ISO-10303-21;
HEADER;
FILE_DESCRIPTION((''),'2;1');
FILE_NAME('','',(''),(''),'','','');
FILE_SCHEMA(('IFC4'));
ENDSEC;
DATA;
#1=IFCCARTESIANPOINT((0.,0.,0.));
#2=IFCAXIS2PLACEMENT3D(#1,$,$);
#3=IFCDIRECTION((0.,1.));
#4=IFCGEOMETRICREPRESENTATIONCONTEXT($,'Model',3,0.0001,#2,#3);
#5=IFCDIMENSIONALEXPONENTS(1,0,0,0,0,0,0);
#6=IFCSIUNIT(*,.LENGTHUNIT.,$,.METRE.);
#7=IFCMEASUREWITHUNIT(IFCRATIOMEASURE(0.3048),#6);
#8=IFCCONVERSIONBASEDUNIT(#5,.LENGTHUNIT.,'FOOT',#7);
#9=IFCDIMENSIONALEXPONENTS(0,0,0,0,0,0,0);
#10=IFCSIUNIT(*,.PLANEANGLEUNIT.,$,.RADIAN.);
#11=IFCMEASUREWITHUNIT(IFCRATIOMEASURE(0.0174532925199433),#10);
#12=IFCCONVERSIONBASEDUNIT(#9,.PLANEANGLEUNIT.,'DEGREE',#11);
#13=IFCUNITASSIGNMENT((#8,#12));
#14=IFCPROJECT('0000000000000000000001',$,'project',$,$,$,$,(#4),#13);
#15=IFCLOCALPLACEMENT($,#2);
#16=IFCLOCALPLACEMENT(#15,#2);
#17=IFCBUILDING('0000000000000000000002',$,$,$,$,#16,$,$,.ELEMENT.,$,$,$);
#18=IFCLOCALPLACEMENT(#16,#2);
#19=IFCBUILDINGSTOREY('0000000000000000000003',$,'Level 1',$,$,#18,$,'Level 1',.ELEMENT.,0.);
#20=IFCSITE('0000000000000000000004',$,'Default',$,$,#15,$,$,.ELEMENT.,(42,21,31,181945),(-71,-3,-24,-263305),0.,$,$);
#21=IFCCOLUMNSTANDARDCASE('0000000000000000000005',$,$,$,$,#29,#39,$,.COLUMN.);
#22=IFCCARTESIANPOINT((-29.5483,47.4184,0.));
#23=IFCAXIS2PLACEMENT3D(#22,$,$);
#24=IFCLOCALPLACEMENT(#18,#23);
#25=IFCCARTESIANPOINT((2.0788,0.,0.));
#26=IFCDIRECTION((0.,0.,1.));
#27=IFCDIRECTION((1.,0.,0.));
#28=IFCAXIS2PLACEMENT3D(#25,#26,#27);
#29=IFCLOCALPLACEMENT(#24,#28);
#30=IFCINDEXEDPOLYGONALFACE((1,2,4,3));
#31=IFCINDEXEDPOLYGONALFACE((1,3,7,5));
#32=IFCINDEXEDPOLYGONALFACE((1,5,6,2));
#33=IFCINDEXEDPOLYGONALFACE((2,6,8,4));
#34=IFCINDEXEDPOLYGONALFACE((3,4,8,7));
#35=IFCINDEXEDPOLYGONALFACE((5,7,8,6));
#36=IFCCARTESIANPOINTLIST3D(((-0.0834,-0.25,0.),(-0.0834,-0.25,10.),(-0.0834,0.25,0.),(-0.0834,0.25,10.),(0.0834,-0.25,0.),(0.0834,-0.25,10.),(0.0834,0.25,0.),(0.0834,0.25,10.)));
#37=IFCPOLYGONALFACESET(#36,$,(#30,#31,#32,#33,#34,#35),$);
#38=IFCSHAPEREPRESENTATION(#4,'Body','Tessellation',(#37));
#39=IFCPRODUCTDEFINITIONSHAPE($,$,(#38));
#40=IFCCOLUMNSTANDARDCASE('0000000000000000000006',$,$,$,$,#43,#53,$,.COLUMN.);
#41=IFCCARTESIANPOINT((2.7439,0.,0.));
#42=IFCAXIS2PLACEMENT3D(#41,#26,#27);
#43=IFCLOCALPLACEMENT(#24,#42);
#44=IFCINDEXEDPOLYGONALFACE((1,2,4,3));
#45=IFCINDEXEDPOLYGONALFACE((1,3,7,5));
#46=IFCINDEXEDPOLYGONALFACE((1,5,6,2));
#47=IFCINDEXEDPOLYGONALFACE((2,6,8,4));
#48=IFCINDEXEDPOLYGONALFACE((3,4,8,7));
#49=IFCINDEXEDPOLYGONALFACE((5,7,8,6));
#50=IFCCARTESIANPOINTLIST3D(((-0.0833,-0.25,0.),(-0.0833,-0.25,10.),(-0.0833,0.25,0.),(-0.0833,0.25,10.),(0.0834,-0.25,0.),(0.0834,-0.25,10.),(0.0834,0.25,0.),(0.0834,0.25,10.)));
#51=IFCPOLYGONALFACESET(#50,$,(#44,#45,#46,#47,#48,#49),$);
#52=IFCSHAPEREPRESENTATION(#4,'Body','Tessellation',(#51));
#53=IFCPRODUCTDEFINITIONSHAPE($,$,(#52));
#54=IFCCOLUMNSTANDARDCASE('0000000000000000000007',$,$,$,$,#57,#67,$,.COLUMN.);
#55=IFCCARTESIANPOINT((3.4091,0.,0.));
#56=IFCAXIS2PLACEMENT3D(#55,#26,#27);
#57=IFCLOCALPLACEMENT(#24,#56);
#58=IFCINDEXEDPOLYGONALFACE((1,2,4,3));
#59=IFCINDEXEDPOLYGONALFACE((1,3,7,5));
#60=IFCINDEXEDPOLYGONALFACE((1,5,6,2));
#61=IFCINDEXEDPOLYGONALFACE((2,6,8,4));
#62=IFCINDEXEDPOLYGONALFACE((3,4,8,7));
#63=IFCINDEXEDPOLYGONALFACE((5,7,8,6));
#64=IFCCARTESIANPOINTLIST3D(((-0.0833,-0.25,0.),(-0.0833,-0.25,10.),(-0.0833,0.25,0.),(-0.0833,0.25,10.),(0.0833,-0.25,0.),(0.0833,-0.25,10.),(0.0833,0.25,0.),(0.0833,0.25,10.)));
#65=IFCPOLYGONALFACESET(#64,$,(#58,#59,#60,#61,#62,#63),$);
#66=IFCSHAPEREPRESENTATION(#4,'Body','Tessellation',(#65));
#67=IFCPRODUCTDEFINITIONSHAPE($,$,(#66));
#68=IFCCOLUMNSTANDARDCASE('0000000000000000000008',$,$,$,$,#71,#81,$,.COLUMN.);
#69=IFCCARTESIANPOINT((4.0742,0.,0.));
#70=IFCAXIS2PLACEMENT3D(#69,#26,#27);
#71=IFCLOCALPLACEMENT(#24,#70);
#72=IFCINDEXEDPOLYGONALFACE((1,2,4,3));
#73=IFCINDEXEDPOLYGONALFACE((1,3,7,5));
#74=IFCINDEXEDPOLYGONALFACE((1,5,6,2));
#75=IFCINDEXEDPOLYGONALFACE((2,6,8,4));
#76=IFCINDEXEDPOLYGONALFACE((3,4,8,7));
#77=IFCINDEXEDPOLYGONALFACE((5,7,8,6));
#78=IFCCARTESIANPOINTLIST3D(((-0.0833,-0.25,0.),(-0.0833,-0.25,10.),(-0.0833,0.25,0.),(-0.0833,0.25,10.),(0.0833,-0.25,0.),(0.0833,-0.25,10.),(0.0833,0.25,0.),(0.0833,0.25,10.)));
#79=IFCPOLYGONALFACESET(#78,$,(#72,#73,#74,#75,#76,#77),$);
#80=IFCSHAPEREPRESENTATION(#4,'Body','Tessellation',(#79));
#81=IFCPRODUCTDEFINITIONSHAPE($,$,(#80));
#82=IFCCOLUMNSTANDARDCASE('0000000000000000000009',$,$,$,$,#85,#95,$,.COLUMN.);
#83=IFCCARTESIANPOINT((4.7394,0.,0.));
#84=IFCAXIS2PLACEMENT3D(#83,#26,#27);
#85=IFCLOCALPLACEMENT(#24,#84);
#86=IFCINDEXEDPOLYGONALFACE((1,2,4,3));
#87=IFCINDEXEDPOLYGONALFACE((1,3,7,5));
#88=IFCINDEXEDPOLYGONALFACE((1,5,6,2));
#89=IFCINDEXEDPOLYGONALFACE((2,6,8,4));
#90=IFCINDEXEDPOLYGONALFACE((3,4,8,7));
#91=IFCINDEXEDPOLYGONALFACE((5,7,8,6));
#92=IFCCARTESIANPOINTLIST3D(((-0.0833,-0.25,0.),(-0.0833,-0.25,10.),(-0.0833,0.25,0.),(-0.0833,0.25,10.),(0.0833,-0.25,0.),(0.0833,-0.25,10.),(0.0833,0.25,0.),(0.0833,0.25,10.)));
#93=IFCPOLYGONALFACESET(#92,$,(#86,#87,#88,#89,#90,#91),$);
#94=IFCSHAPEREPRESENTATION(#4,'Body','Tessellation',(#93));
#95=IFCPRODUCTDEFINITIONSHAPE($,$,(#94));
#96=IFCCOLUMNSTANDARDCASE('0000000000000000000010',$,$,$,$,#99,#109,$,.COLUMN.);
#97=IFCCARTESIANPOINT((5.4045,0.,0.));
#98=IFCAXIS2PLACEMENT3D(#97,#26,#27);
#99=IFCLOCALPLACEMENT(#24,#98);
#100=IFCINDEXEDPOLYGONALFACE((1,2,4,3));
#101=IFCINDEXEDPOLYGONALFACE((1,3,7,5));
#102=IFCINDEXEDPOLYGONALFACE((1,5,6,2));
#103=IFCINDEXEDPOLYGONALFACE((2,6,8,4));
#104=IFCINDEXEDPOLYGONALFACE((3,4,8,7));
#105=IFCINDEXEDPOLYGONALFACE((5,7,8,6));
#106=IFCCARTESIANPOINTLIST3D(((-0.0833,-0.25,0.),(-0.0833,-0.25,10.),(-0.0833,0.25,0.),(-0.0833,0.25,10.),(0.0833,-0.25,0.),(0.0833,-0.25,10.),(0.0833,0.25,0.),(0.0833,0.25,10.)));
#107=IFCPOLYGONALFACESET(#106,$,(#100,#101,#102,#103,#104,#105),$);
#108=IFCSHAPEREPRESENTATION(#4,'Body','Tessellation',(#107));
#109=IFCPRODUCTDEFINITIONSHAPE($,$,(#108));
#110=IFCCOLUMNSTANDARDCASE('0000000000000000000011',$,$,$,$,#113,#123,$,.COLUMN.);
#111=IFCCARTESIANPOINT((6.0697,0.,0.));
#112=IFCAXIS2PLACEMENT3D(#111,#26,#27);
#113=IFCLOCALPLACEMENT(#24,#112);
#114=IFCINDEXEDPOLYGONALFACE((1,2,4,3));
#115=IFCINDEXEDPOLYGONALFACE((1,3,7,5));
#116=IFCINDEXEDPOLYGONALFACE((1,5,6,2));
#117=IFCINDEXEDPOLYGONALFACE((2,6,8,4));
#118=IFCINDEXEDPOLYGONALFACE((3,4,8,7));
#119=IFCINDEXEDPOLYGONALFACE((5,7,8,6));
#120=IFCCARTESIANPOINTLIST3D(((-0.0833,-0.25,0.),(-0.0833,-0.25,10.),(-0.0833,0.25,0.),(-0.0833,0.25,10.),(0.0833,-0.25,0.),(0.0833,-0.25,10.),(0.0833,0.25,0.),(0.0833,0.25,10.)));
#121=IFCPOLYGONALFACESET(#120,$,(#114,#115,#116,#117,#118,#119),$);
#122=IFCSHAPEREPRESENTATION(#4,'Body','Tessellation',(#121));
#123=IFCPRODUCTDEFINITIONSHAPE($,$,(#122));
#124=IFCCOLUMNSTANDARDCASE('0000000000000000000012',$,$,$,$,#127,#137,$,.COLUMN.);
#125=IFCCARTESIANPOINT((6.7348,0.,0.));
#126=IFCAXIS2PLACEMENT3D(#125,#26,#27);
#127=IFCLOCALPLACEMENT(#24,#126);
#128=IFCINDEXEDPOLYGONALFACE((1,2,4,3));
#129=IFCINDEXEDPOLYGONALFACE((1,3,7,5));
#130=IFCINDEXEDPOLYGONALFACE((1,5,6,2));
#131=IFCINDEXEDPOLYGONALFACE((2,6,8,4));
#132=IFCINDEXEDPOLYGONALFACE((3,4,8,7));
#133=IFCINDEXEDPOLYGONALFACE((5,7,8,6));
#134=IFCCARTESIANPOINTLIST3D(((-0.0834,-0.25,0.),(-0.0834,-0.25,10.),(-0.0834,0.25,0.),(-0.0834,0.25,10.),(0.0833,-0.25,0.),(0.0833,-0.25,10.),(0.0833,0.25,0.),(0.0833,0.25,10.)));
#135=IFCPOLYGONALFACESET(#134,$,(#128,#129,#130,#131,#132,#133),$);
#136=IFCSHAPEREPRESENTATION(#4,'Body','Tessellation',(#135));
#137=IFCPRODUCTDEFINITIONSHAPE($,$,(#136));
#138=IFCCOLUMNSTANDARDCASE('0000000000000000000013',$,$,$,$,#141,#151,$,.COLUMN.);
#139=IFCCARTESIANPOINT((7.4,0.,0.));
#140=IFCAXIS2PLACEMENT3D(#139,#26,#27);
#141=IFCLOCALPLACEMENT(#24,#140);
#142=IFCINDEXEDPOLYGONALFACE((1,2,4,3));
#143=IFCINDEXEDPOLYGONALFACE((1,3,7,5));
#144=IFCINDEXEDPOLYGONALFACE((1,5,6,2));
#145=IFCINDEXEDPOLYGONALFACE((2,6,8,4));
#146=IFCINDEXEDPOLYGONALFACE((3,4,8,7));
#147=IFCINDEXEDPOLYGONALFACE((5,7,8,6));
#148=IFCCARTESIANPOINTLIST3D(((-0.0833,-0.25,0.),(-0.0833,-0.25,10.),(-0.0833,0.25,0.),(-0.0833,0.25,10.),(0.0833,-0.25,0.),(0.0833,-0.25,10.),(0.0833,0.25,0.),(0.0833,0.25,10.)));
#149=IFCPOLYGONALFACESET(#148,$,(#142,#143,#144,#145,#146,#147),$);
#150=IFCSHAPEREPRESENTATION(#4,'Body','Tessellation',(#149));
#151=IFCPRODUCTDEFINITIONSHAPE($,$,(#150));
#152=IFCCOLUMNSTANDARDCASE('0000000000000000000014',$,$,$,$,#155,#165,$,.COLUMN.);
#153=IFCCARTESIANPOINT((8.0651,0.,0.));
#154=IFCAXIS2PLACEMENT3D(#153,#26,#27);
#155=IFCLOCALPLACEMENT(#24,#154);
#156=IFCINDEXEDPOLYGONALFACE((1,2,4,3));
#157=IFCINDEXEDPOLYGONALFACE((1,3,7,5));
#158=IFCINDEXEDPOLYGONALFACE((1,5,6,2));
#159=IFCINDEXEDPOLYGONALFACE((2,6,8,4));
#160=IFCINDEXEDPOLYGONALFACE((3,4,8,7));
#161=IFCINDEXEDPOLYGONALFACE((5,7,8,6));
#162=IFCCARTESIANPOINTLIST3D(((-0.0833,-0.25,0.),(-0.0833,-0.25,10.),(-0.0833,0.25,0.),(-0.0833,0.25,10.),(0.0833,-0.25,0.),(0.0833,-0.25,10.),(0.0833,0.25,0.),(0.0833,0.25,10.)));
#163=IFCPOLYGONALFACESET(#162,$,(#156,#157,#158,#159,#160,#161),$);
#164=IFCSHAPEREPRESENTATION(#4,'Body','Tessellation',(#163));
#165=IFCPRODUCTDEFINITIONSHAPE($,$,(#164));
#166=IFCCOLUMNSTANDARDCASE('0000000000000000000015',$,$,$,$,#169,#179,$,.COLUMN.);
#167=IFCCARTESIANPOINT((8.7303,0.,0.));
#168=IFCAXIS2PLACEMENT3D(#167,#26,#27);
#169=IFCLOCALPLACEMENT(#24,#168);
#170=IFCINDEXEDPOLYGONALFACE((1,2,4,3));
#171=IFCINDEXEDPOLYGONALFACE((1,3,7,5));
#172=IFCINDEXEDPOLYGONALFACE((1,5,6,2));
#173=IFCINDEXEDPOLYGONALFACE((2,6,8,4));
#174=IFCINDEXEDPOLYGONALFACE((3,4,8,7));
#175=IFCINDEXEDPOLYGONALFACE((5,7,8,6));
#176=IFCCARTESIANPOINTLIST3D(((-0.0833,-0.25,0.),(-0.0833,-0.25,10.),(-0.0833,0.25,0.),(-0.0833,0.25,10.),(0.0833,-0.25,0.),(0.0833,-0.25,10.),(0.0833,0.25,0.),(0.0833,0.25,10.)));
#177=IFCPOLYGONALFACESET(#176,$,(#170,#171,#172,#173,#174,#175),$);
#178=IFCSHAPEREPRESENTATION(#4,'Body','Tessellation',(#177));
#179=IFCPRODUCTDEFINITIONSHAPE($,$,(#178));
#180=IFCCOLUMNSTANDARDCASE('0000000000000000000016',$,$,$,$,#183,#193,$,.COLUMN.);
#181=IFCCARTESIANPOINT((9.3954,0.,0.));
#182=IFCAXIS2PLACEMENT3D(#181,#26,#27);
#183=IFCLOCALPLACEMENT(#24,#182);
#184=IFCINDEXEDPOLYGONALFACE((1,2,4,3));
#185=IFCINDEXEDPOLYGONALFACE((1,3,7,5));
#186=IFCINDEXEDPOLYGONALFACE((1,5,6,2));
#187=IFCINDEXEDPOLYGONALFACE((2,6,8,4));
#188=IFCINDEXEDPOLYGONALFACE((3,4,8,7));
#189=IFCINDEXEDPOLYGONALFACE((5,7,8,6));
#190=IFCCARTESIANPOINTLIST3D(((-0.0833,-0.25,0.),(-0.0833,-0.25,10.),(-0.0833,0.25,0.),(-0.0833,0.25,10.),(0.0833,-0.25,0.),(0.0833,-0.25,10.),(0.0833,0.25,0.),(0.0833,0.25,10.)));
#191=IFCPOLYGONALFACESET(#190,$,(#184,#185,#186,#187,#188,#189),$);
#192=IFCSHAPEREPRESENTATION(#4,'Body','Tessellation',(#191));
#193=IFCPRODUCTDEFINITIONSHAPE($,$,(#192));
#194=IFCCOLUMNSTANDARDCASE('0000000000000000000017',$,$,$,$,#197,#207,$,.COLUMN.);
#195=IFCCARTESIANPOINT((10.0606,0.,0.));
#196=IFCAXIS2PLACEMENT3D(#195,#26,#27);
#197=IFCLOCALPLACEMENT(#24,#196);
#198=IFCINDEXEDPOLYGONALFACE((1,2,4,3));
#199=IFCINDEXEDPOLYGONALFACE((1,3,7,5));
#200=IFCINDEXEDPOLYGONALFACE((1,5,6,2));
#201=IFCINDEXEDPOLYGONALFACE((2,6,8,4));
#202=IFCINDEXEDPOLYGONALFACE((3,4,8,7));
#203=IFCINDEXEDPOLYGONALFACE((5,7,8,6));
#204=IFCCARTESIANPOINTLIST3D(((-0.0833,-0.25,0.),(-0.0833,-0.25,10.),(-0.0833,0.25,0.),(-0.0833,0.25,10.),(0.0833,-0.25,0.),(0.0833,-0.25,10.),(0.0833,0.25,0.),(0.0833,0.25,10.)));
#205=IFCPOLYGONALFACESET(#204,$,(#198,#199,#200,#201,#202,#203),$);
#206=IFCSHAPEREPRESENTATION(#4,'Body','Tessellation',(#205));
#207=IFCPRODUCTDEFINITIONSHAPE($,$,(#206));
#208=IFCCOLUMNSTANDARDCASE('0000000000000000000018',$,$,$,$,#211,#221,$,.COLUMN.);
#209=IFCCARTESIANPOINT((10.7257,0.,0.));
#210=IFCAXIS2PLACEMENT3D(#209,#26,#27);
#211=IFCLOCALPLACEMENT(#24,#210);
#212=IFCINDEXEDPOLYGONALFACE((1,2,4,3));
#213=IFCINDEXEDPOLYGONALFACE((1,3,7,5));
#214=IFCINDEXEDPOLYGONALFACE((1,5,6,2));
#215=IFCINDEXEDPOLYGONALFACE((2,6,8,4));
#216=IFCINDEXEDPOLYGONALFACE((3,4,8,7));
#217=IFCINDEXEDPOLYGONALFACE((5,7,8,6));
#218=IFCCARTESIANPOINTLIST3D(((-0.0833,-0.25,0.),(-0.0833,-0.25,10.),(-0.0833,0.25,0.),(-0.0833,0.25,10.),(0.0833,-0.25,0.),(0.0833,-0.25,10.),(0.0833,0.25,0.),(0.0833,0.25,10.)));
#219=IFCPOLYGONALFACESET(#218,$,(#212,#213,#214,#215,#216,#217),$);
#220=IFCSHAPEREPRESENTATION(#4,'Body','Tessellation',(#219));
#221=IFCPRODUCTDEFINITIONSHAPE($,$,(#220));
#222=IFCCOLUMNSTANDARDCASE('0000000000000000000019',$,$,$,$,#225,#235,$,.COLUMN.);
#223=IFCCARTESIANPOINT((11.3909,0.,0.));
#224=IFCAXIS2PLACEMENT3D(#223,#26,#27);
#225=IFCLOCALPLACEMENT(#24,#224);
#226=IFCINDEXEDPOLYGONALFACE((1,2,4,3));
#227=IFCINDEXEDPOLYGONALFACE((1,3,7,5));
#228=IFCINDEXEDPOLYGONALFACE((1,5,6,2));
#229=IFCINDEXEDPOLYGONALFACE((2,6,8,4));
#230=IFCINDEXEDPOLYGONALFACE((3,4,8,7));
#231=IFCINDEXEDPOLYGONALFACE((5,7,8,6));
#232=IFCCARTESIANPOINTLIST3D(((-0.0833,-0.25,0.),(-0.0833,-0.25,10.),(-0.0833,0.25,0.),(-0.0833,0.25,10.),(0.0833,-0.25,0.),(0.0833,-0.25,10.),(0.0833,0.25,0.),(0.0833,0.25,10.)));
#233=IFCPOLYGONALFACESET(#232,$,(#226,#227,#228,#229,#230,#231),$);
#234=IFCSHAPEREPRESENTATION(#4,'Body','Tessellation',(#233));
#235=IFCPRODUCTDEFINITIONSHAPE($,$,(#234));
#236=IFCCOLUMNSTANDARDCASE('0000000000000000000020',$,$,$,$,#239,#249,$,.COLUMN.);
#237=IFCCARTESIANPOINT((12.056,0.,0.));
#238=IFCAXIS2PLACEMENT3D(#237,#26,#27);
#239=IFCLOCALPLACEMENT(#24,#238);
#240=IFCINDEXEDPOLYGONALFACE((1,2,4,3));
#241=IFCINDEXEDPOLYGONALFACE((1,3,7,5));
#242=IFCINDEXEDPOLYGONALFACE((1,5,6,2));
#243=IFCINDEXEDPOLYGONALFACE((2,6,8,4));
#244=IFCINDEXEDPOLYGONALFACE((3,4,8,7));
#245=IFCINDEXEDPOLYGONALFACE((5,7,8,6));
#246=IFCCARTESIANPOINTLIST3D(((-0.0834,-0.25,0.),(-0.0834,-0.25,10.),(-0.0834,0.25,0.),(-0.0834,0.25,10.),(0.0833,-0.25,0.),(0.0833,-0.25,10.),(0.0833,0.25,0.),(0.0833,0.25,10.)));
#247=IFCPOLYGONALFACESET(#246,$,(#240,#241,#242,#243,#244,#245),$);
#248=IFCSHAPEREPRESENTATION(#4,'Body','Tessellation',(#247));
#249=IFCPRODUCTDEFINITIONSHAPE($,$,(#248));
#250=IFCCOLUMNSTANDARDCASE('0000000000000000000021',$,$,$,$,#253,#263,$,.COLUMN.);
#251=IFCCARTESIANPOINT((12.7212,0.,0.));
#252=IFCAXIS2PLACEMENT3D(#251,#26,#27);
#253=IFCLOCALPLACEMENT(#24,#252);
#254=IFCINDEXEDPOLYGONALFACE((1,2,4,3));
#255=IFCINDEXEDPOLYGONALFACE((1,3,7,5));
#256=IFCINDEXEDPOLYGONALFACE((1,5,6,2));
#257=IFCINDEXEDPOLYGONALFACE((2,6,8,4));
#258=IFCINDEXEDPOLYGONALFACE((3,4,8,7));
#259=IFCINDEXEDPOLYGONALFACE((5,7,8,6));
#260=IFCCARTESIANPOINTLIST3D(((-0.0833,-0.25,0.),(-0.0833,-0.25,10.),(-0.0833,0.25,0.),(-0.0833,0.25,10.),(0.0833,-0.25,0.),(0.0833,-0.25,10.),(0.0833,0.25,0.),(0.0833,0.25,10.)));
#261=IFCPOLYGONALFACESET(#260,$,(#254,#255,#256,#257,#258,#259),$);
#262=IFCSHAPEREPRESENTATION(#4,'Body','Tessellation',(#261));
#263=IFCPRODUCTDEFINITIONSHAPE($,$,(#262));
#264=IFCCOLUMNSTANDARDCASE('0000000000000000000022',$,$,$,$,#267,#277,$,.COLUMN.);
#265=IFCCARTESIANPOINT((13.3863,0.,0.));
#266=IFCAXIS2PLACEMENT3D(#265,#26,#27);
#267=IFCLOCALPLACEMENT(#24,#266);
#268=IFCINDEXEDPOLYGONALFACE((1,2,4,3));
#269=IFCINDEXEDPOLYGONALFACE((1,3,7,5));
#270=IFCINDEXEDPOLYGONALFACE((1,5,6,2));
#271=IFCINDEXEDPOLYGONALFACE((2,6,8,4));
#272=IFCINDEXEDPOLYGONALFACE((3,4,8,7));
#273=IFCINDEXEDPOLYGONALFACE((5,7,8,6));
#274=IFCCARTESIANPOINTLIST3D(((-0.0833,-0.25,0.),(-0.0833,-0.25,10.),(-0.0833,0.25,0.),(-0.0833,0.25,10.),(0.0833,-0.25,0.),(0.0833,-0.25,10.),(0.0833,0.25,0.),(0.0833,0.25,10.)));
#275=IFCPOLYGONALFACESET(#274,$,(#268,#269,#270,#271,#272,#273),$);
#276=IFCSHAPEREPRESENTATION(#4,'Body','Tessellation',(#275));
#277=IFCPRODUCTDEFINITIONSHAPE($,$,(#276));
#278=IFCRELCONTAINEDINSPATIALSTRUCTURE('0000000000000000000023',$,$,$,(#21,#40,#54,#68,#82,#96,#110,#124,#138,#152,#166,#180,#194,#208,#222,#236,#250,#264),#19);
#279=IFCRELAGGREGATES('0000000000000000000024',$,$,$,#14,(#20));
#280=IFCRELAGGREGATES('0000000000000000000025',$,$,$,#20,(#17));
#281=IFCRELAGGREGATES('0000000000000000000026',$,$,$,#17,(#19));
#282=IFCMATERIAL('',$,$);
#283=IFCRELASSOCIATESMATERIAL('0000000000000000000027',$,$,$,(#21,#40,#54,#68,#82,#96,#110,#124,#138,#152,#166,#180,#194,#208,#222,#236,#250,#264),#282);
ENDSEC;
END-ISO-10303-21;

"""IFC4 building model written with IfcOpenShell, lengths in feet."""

from ifc_helpers import new_model, entity, si_unit, converted_unit, direction, frame, origin, place, context, project, spatial, rectangle, extrude, material, element, save


model = new_model("IFC4")

# Units and contexts
model_context = context("Model", 3, precision=0.0001, world=origin(), true_north=direction((0.0, 1.0)))
ifc_project = project(units=[converted_unit("LENGTHUNIT", "FOOT", entity("IfcRatioMeasure", 0.3048), si_unit("LENGTHUNIT", "METRE"), dimensions=[1, 0, 0, 0, 0, 0, 0]), converted_unit("PLANEANGLEUNIT", "DEGREE", entity("IfcRatioMeasure", 0.0174532925199433), si_unit("PLANEANGLEUNIT", "RADIAN"), dimensions=[0, 0, 0, 0, 0, 0, 0])], contexts=[model_context])

# Site, building, storey
site_placement = place(None, origin())
site = spatial("IfcSite", under=ifc_project, at=site_placement, Name="Default", CompositionType="ELEMENT", RefLatitude=(42, 21, 31, 181945), RefLongitude=(-71, -3, -24, -263305), RefElevation=0.0)
building_placement = place(site_placement, origin())
building = spatial("IfcBuilding", under=site, at=building_placement, CompositionType="ELEMENT")
storey_placement = place(building_placement, origin())
storey = spatial("IfcBuildingStorey", under=building, at=storey_placement, Name="Level 1", LongName="Level 1", CompositionType="ELEMENT", Elevation=0.0)

# Columns
ifc_material = material(Name="")
placement = place(storey_placement, frame((-29.5483, 47.4184, 0.0)))
for number, where, z_axis, x_axis in (
    (1, (2.0788, 0.0, 0.0), (0.0, 0.0, 1.0), (1.0, 0.0, 0.0)),
    (2, (2.7439, 0.0, 0.0), (0.0, 0.0, 1.0), (1.0, 0.0, 0.0)),
    (3, (3.4091, 0.0, 0.0), (0.0, 0.0, 1.0), (1.0, 0.0, 0.0)),
    (4, (4.0742, 0.0, 0.0), (0.0, 0.0, 1.0), (1.0, 0.0, 0.0)),
    (5, (4.7394, 0.0, 0.0), (0.0, 0.0, 1.0), (1.0, 0.0, 0.0)),
    (6, (5.4045, 0.0, 0.0), (0.0, 0.0, 1.0), (1.0, 0.0, 0.0)),
    (7, (6.0697, 0.0, 0.0), (0.0, 0.0, 1.0), (1.0, 0.0, 0.0)),
    (8, (6.7348, 0.0, 0.0), (0.0, 0.0, 1.0), (1.0, 0.0, 0.0)),
    (9, (7.4, 0.0, 0.0), (0.0, 0.0, 1.0), (1.0, 0.0, 0.0)),
    (10, (8.0651, 0.0, 0.0), (0.0, 0.0, 1.0), (1.0, 0.0, 0.0)),
    (11, (8.7303, 0.0, 0.0), (0.0, 0.0, 1.0), (1.0, 0.0, 0.0)),
    (12, (9.3954, 0.0, 0.0), (0.0, 0.0, 1.0), (1.0, 0.0, 0.0)),
    (13, (10.0606, 0.0, 0.0), (0.0, 0.0, 1.0), (1.0, 0.0, 0.0)),
    (14, (10.7257, 0.0, 0.0), (0.0, 0.0, 1.0), (1.0, 0.0, 0.0)),
    (15, (11.3909, 0.0, 0.0), (0.0, 0.0, 1.0), (1.0, 0.0, 0.0)),
    (16, (12.056, 0.0, 0.0), (0.0, 0.0, 1.0), (1.0, 0.0, 0.0)),
    (17, (12.7212, 0.0, 0.0), (0.0, 0.0, 1.0), (1.0, 0.0, 0.0)),
    (18, (13.3863, 0.0, 0.0), (0.0, 0.0, 1.0), (1.0, 0.0, 0.0)),
):
    element("IfcColumnStandardCase", number, at=place(placement, frame(where, z_axis=z_axis, x_axis=x_axis)), inside=storey, material=ifc_material, PredefinedType="COLUMN", context=model_context, shape_type="SweptSolid", body=[
        extrude(rectangle(XDim=0.1667, YDim=0.5), origin(), (0.0, 0.0, 1.0), 10.0),
    ])

save(model, "model.ifc")
